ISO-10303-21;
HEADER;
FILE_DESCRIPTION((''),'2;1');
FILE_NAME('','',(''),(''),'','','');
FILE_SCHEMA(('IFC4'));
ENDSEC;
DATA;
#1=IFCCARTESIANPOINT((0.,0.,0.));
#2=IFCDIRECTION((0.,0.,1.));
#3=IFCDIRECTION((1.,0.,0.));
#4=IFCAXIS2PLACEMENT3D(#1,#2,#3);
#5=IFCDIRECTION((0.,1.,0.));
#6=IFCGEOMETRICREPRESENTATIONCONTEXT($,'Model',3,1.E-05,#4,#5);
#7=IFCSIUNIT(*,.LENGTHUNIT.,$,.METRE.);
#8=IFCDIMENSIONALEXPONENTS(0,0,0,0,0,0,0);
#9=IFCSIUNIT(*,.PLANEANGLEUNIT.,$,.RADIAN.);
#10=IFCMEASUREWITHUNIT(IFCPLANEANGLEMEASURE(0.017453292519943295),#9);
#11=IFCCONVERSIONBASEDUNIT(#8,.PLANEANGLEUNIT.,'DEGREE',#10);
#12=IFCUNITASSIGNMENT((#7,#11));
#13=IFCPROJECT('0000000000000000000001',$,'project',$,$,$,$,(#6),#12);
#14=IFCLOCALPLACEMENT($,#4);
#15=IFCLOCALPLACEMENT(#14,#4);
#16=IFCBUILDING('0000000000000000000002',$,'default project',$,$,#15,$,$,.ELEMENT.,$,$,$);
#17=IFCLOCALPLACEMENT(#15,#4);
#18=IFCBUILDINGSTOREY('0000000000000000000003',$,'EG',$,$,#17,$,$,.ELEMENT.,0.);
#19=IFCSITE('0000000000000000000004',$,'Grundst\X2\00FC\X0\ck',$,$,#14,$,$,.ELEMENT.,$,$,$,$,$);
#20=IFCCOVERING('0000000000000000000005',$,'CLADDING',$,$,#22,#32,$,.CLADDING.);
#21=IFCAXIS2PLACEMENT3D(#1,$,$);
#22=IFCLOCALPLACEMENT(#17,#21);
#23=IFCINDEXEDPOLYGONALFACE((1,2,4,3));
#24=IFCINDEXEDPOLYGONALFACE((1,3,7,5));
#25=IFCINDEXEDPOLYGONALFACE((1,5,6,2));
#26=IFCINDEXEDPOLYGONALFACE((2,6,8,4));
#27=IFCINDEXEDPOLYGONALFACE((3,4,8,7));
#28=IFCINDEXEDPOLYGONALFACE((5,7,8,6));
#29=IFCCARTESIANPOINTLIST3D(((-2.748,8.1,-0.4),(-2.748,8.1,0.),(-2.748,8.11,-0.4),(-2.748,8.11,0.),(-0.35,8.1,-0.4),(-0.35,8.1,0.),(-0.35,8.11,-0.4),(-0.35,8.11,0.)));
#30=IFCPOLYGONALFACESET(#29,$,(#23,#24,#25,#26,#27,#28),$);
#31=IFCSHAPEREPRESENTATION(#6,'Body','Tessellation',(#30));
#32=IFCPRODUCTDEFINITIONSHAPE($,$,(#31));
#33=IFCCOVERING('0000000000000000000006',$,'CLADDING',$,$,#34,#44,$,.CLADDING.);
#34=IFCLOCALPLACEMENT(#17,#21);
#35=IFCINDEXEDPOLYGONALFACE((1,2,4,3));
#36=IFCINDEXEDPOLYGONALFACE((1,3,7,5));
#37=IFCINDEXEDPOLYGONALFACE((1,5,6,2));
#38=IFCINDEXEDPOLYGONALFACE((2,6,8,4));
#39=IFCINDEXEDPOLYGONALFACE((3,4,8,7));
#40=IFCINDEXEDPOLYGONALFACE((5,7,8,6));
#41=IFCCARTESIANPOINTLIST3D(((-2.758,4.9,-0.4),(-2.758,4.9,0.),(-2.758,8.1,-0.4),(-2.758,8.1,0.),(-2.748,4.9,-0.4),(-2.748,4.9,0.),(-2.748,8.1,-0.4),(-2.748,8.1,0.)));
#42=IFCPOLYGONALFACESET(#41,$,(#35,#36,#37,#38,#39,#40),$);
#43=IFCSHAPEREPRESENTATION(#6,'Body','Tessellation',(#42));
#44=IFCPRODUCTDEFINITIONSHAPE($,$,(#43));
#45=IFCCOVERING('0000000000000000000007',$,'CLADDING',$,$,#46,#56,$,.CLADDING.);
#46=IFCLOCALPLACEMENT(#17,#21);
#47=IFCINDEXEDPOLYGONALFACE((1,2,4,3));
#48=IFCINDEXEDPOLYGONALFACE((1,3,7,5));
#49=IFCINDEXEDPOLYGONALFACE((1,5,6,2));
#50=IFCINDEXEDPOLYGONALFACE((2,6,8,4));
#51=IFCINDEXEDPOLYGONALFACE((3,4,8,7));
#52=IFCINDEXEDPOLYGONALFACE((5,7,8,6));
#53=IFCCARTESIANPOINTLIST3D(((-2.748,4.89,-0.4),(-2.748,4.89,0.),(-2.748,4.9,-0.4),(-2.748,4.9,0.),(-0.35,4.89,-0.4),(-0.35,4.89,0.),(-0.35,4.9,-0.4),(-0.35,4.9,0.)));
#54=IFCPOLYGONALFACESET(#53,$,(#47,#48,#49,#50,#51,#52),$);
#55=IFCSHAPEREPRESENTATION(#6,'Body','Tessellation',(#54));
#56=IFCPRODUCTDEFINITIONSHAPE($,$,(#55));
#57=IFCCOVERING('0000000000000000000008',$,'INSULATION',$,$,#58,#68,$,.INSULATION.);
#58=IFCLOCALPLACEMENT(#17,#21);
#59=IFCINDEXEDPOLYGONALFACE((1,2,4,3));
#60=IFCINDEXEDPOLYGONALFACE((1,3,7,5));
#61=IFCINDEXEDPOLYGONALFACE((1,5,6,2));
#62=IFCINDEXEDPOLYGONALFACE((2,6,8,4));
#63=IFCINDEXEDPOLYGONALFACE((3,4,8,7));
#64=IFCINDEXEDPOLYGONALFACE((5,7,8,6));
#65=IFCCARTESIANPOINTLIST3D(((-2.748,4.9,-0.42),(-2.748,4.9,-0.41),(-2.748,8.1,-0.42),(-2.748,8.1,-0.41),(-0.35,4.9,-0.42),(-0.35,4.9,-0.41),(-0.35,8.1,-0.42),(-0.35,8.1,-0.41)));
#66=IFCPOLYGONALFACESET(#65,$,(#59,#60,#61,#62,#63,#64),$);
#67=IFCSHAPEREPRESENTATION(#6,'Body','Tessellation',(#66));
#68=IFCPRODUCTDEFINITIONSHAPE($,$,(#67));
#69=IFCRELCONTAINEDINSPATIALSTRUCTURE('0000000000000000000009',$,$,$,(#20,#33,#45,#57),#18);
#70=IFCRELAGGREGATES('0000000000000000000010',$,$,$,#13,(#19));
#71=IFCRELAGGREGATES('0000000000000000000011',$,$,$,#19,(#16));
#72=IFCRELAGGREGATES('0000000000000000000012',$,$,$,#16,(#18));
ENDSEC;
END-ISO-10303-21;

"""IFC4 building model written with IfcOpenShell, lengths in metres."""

from ifc_helpers import new_model, entity, si_unit, converted_unit, direction, frame, origin_with_axes, place, context, project, spatial, polyline, outline, extrude, element, save


model = new_model("IFC4")

# Units and contexts
model_context = context("Model", 3, precision=1e-05, world=origin_with_axes(), true_north=direction((0.0, 1.0, 0.0)))
ifc_project = project(units=[si_unit("LENGTHUNIT", "METRE"), converted_unit("PLANEANGLEUNIT", "DEGREE", entity("IfcPlaneAngleMeasure", 0.017453292519943295), si_unit("PLANEANGLEUNIT", "RADIAN"), dimensions=[0, 0, 0, 0, 0, 0, 0])], contexts=[model_context])

# Site, building, storey
site_placement = place(None, origin_with_axes())
site = spatial("IfcSite", under=ifc_project, at=site_placement, Name="Grundstück", CompositionType="ELEMENT")
building_placement = place(site_placement, origin_with_axes())
building = spatial("IfcBuilding", under=site, at=building_placement, Name="default project", CompositionType="ELEMENT")
placement_1 = place(building_placement, origin_with_axes())
storey = spatial("IfcBuildingStorey", under=building, at=placement_1, Name="EG", CompositionType="ELEMENT", Elevation=0.0)

# Shared definitions
slab_1_placement = place(placement_1, frame((0.0, 0.0, -0.4), z_axis=(0.0, 0.0, 1.0), x_axis=(1.0, 0.0, 0.0)))

# Coverings
covering_1_placement = place(slab_1_placement, origin_with_axes())
element("IfcCovering", 1, at=covering_1_placement, inside=storey, Name="CLADDING", PredefinedType="CLADDING", context=model_context, shape_type="SweptSolid", body=[
    extrude(outline(polyline([(-0.35, 8.11), (-2.748, 8.11), (-2.748, 8.1), (-0.35, 8.1), (-0.35, 8.11)])), origin_with_axes(), (0.0, 0.0, 1.0), 0.4),
])
covering_2_placement = place(slab_1_placement, origin_with_axes())
element("IfcCovering", 2, at=covering_2_placement, inside=storey, Name="CLADDING", PredefinedType="CLADDING", context=model_context, shape_type="SweptSolid", body=[
    extrude(outline(polyline([(-2.758, 8.1), (-2.758, 4.9), (-2.748, 4.9), (-2.748, 8.1), (-2.758, 8.1)])), origin_with_axes(), (0.0, 0.0, 1.0), 0.4),
])
covering_3_placement = place(slab_1_placement, origin_with_axes())
element("IfcCovering", 3, at=covering_3_placement, inside=storey, Name="CLADDING", PredefinedType="CLADDING", context=model_context, shape_type="SweptSolid", body=[
    extrude(outline(polyline([(-2.748, 4.89), (-0.35, 4.89), (-0.35, 4.9), (-2.748, 4.9), (-2.748, 4.89)])), origin_with_axes(), (0.0, 0.0, 1.0), 0.4),
])
covering_4_placement = place(slab_1_placement, frame((0.0, 0.0, -0.01), z_axis=(0.0, 0.0, 1.0), x_axis=(1.0, 0.0, 0.0)))
element("IfcCovering", 4, at=covering_4_placement, inside=storey, Name="INSULATION", PredefinedType="INSULATION", context=model_context, shape_type="SweptSolid", body=[
    extrude(outline(polyline([(-0.35, 8.1), (-2.748, 8.1), (-2.748, 4.9), (-0.35, 4.9), (-0.35, 8.1)])), frame((0.0, 0.0, -0.01), z_axis=(0.0, 0.0, 1.0), x_axis=(1.0, 0.0, 0.0)), (0.0, 0.0, 1.0), 0.01),
])

save(model, "model.ifc")
